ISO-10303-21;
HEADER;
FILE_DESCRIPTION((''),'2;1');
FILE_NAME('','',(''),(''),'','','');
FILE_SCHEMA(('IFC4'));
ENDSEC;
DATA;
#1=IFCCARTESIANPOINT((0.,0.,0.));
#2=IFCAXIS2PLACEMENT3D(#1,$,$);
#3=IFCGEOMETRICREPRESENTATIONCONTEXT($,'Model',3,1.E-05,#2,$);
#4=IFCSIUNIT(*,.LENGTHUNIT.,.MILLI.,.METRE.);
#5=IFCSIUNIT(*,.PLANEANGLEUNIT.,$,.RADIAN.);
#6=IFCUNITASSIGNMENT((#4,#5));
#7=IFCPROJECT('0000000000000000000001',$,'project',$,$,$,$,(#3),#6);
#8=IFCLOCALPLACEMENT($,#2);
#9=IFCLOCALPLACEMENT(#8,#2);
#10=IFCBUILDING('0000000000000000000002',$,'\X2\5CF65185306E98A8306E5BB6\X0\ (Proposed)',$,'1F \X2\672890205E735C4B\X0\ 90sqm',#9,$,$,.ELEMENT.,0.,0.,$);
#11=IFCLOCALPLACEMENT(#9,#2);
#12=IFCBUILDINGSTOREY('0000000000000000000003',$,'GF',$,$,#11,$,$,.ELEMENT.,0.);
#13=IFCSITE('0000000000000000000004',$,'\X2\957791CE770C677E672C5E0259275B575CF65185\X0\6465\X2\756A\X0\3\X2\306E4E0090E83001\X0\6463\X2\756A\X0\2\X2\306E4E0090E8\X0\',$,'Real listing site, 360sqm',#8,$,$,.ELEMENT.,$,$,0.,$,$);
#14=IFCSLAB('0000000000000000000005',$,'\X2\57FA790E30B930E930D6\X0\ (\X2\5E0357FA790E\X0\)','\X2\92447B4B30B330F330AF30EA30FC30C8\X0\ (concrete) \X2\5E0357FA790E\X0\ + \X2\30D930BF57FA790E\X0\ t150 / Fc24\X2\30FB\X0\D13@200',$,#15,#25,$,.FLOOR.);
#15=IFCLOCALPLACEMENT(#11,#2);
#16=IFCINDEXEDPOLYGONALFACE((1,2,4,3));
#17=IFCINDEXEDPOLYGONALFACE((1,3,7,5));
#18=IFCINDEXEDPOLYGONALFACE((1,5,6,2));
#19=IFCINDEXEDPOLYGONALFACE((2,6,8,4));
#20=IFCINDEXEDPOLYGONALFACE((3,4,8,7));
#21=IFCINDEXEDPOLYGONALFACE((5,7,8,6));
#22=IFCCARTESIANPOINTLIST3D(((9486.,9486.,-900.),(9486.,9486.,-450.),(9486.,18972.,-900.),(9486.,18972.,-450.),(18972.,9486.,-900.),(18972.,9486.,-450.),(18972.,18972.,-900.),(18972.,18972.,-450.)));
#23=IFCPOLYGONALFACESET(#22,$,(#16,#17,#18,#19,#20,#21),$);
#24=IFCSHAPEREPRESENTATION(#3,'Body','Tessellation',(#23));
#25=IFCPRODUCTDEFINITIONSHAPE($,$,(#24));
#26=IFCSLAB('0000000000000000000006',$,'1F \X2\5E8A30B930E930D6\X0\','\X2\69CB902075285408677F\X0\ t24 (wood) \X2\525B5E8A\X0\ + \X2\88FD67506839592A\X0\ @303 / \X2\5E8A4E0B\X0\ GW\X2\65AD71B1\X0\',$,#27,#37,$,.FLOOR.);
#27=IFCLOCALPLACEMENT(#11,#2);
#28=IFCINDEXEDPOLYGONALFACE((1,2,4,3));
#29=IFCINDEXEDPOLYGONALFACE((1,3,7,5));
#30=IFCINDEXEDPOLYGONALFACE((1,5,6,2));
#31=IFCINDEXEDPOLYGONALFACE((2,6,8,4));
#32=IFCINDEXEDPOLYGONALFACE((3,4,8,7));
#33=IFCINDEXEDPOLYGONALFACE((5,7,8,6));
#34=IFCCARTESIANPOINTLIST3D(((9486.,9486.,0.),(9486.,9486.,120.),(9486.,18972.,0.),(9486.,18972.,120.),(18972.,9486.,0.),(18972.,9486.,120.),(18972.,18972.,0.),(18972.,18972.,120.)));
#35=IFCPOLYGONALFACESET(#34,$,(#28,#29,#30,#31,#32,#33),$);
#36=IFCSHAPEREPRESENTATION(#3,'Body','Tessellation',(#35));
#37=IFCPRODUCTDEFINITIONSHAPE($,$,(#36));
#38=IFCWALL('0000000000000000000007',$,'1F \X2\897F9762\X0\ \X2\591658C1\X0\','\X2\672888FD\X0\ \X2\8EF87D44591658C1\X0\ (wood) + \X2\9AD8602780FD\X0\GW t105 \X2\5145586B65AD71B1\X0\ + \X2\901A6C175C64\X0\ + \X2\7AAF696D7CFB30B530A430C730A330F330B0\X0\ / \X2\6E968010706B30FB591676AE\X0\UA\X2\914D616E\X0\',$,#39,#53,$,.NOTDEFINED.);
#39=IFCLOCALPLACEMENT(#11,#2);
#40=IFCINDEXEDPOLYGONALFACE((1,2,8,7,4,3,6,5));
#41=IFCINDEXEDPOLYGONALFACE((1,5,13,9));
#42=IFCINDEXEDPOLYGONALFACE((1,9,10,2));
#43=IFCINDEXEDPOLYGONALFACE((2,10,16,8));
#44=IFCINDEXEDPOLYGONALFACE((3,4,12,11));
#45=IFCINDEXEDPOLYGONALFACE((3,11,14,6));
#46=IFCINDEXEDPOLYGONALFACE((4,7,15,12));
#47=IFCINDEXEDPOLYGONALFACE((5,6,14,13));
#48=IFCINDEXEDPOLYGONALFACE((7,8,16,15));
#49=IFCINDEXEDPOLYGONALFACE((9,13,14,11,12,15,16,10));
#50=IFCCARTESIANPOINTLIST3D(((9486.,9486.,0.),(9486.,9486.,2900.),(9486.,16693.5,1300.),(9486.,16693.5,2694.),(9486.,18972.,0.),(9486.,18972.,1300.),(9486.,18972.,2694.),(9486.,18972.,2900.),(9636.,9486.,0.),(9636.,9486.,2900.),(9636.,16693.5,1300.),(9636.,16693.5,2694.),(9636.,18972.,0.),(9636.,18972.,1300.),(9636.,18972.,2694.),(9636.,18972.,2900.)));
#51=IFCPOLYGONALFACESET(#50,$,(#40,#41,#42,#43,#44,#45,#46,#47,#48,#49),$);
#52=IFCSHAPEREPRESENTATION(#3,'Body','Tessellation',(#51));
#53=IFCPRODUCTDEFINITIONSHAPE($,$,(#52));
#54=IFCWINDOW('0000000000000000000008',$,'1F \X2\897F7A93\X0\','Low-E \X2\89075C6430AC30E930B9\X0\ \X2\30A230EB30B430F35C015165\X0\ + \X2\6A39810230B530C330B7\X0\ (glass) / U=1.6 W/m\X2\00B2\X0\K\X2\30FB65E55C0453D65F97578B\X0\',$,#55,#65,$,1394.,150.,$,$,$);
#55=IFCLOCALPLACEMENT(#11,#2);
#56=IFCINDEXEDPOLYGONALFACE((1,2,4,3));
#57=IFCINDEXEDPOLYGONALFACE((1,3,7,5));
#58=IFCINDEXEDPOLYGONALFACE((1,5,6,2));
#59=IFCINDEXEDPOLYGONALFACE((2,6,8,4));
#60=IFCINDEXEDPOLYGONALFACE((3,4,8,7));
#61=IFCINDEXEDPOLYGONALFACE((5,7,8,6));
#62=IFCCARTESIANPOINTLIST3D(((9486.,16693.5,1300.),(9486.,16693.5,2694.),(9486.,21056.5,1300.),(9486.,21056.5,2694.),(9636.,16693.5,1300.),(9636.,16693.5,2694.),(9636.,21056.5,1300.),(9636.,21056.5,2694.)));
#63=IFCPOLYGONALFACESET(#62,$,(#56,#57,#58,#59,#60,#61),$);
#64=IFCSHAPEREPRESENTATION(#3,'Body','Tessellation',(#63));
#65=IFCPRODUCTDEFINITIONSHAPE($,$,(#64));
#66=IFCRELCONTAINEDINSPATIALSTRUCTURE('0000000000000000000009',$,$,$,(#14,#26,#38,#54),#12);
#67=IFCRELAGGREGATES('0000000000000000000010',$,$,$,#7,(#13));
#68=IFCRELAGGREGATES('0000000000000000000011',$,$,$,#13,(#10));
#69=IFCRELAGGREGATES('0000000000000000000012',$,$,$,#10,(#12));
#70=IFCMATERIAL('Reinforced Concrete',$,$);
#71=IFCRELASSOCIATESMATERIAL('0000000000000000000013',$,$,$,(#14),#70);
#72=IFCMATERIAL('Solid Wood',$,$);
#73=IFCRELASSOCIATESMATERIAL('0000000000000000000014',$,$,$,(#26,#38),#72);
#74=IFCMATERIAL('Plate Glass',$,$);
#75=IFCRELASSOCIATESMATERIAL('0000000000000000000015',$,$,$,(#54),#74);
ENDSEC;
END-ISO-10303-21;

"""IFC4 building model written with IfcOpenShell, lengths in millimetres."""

from ifc_helpers import new_model, si_unit, frame, frame_2d, origin, place, context, project, spatial, rectangle, extrude, material, element, fill, save


model = new_model("IFC4")

# Units and contexts
model_context = context("Model", 3, precision=1e-05, world=origin())
ifc_project = project(units=[si_unit("LENGTHUNIT", "METRE", prefix="MILLI"), si_unit("PLANEANGLEUNIT", "RADIAN")], contexts=[model_context])

# Site, building, storey
site_placement = place(None, origin())
site = spatial("IfcSite", under=ifc_project, at=site_placement, Name="長野県松本市大字島内6465番3の一部、6463番2の一部", ObjectType="Real listing site, 360sqm", CompositionType="ELEMENT", RefElevation=0.0)
building_placement = place(site_placement, origin())
building = spatial("IfcBuilding", under=site, at=building_placement, Name="島内の風の家 (Proposed)", ObjectType="1F 木造平屋 90sqm", CompositionType="ELEMENT", ElevationOfRefHeight=0.0, ElevationOfTerrain=0.0)
storey_placement = place(building_placement, origin())
storey = spatial("IfcBuildingStorey", under=building, at=storey_placement, Name="GF", CompositionType="ELEMENT", Elevation=0.0)

# Slabs
ifc_material_1 = material(Name="Reinforced Concrete")
slab_1_placement = place(storey_placement, frame((4743.0, 4743.0, -450.0)))
element("IfcSlab", 1, at=slab_1_placement, inside=storey, material=ifc_material_1, Name="基礎スラブ (布基礎)", Description="鉄筋コンクリート (concrete) 布基礎 + ベタ基礎 t150 / Fc24・D13@200", PredefinedType="FLOOR", context=model_context, shape_type="SweptSolid", body=[
    extrude(rectangle(XDim=9486.0, YDim=9486.0, at=frame_2d((4743.0, 4743.0))), frame((4743.0, 4743.0, -450.0)), (0.0, 0.0, 1.0), 450.0),
])
ifc_material_2 = material(Name="Solid Wood")
slab_2_placement = place(storey_placement, frame((4743.0, 4743.0, 0.0)))
element("IfcSlab", 2, at=slab_2_placement, inside=storey, material=ifc_material_2, Name="1F 床スラブ", Description="構造用合板 t24 (wood) 剛床 + 製材根太 @303 / 床下 GW断熱", PredefinedType="FLOOR", context=model_context, shape_type="SweptSolid", body=[
    extrude(rectangle(XDim=9486.0, YDim=9486.0, at=frame_2d((4743.0, 4743.0))), frame((4743.0, 4743.0, 0.0)), (0.0, 0.0, 1.0), 120.0),
])

# Shared definitions
ifc_material_3 = material(Name="Plate Glass")

# Wall, opening, window
wall_1_placement = place(storey_placement, frame((4743.0, 4743.0, 0.0)))
wall_1 = element("IfcWall", 3, at=wall_1_placement, inside=storey, material=ifc_material_2, Name="1F 西面 外壁", Description="木製 軸組外壁 (wood) + 高性能GW t105 充填断熱 + 通気層 + 窯業系サイディング / 準耐火・外皮UA配慮", PredefinedType="NOTDEFINED", context=model_context, shape_type="SweptSolid", body=[
    extrude(rectangle(XDim=150.0, YDim=9486.0, at=frame_2d((75.0, 4743.0))), frame((4743.0, 4743.0, 0.0)), (0.0, 0.0, 1.0), 2900.0),
])
opening_1_placement = place(storey_placement, frame((4743.0, 8347.0, 650.0)))
opening_1 = element("IfcOpeningElement", 4, at=opening_1_placement, cuts=wall_1, PredefinedType="NOTDEFINED", context=model_context, shape_type="SweptSolid", body=[
    extrude(rectangle(XDim=150.0, YDim=4363.0, at=frame_2d((75.0, 2181.0))), frame((4743.0, 8347.0, 650.0)), (0.0, 0.0, 1.0), 1394.0),
])
window_1_placement = place(storey_placement, frame((4743.0, 8347.0, 650.0)))
window_1 = element("IfcWindow", 5, at=window_1_placement, inside=storey, material=ifc_material_3, Name="1F 西窓", Description="Low-E 複層ガラス アルゴン封入 + 樹脂サッシ (glass) / U=1.6 W/m²K・日射取得型", OverallHeight=1394.0, OverallWidth=150.0, context=model_context, shape_type="SweptSolid", body=[
    extrude(rectangle(XDim=150.0, YDim=4363.0, at=frame_2d((75.0, 2181.0))), frame((4743.0, 8347.0, 650.0)), (0.0, 0.0, 1.0), 1394.0),
])
fill(opening_1, window_1)

save(model, "model.ifc")
